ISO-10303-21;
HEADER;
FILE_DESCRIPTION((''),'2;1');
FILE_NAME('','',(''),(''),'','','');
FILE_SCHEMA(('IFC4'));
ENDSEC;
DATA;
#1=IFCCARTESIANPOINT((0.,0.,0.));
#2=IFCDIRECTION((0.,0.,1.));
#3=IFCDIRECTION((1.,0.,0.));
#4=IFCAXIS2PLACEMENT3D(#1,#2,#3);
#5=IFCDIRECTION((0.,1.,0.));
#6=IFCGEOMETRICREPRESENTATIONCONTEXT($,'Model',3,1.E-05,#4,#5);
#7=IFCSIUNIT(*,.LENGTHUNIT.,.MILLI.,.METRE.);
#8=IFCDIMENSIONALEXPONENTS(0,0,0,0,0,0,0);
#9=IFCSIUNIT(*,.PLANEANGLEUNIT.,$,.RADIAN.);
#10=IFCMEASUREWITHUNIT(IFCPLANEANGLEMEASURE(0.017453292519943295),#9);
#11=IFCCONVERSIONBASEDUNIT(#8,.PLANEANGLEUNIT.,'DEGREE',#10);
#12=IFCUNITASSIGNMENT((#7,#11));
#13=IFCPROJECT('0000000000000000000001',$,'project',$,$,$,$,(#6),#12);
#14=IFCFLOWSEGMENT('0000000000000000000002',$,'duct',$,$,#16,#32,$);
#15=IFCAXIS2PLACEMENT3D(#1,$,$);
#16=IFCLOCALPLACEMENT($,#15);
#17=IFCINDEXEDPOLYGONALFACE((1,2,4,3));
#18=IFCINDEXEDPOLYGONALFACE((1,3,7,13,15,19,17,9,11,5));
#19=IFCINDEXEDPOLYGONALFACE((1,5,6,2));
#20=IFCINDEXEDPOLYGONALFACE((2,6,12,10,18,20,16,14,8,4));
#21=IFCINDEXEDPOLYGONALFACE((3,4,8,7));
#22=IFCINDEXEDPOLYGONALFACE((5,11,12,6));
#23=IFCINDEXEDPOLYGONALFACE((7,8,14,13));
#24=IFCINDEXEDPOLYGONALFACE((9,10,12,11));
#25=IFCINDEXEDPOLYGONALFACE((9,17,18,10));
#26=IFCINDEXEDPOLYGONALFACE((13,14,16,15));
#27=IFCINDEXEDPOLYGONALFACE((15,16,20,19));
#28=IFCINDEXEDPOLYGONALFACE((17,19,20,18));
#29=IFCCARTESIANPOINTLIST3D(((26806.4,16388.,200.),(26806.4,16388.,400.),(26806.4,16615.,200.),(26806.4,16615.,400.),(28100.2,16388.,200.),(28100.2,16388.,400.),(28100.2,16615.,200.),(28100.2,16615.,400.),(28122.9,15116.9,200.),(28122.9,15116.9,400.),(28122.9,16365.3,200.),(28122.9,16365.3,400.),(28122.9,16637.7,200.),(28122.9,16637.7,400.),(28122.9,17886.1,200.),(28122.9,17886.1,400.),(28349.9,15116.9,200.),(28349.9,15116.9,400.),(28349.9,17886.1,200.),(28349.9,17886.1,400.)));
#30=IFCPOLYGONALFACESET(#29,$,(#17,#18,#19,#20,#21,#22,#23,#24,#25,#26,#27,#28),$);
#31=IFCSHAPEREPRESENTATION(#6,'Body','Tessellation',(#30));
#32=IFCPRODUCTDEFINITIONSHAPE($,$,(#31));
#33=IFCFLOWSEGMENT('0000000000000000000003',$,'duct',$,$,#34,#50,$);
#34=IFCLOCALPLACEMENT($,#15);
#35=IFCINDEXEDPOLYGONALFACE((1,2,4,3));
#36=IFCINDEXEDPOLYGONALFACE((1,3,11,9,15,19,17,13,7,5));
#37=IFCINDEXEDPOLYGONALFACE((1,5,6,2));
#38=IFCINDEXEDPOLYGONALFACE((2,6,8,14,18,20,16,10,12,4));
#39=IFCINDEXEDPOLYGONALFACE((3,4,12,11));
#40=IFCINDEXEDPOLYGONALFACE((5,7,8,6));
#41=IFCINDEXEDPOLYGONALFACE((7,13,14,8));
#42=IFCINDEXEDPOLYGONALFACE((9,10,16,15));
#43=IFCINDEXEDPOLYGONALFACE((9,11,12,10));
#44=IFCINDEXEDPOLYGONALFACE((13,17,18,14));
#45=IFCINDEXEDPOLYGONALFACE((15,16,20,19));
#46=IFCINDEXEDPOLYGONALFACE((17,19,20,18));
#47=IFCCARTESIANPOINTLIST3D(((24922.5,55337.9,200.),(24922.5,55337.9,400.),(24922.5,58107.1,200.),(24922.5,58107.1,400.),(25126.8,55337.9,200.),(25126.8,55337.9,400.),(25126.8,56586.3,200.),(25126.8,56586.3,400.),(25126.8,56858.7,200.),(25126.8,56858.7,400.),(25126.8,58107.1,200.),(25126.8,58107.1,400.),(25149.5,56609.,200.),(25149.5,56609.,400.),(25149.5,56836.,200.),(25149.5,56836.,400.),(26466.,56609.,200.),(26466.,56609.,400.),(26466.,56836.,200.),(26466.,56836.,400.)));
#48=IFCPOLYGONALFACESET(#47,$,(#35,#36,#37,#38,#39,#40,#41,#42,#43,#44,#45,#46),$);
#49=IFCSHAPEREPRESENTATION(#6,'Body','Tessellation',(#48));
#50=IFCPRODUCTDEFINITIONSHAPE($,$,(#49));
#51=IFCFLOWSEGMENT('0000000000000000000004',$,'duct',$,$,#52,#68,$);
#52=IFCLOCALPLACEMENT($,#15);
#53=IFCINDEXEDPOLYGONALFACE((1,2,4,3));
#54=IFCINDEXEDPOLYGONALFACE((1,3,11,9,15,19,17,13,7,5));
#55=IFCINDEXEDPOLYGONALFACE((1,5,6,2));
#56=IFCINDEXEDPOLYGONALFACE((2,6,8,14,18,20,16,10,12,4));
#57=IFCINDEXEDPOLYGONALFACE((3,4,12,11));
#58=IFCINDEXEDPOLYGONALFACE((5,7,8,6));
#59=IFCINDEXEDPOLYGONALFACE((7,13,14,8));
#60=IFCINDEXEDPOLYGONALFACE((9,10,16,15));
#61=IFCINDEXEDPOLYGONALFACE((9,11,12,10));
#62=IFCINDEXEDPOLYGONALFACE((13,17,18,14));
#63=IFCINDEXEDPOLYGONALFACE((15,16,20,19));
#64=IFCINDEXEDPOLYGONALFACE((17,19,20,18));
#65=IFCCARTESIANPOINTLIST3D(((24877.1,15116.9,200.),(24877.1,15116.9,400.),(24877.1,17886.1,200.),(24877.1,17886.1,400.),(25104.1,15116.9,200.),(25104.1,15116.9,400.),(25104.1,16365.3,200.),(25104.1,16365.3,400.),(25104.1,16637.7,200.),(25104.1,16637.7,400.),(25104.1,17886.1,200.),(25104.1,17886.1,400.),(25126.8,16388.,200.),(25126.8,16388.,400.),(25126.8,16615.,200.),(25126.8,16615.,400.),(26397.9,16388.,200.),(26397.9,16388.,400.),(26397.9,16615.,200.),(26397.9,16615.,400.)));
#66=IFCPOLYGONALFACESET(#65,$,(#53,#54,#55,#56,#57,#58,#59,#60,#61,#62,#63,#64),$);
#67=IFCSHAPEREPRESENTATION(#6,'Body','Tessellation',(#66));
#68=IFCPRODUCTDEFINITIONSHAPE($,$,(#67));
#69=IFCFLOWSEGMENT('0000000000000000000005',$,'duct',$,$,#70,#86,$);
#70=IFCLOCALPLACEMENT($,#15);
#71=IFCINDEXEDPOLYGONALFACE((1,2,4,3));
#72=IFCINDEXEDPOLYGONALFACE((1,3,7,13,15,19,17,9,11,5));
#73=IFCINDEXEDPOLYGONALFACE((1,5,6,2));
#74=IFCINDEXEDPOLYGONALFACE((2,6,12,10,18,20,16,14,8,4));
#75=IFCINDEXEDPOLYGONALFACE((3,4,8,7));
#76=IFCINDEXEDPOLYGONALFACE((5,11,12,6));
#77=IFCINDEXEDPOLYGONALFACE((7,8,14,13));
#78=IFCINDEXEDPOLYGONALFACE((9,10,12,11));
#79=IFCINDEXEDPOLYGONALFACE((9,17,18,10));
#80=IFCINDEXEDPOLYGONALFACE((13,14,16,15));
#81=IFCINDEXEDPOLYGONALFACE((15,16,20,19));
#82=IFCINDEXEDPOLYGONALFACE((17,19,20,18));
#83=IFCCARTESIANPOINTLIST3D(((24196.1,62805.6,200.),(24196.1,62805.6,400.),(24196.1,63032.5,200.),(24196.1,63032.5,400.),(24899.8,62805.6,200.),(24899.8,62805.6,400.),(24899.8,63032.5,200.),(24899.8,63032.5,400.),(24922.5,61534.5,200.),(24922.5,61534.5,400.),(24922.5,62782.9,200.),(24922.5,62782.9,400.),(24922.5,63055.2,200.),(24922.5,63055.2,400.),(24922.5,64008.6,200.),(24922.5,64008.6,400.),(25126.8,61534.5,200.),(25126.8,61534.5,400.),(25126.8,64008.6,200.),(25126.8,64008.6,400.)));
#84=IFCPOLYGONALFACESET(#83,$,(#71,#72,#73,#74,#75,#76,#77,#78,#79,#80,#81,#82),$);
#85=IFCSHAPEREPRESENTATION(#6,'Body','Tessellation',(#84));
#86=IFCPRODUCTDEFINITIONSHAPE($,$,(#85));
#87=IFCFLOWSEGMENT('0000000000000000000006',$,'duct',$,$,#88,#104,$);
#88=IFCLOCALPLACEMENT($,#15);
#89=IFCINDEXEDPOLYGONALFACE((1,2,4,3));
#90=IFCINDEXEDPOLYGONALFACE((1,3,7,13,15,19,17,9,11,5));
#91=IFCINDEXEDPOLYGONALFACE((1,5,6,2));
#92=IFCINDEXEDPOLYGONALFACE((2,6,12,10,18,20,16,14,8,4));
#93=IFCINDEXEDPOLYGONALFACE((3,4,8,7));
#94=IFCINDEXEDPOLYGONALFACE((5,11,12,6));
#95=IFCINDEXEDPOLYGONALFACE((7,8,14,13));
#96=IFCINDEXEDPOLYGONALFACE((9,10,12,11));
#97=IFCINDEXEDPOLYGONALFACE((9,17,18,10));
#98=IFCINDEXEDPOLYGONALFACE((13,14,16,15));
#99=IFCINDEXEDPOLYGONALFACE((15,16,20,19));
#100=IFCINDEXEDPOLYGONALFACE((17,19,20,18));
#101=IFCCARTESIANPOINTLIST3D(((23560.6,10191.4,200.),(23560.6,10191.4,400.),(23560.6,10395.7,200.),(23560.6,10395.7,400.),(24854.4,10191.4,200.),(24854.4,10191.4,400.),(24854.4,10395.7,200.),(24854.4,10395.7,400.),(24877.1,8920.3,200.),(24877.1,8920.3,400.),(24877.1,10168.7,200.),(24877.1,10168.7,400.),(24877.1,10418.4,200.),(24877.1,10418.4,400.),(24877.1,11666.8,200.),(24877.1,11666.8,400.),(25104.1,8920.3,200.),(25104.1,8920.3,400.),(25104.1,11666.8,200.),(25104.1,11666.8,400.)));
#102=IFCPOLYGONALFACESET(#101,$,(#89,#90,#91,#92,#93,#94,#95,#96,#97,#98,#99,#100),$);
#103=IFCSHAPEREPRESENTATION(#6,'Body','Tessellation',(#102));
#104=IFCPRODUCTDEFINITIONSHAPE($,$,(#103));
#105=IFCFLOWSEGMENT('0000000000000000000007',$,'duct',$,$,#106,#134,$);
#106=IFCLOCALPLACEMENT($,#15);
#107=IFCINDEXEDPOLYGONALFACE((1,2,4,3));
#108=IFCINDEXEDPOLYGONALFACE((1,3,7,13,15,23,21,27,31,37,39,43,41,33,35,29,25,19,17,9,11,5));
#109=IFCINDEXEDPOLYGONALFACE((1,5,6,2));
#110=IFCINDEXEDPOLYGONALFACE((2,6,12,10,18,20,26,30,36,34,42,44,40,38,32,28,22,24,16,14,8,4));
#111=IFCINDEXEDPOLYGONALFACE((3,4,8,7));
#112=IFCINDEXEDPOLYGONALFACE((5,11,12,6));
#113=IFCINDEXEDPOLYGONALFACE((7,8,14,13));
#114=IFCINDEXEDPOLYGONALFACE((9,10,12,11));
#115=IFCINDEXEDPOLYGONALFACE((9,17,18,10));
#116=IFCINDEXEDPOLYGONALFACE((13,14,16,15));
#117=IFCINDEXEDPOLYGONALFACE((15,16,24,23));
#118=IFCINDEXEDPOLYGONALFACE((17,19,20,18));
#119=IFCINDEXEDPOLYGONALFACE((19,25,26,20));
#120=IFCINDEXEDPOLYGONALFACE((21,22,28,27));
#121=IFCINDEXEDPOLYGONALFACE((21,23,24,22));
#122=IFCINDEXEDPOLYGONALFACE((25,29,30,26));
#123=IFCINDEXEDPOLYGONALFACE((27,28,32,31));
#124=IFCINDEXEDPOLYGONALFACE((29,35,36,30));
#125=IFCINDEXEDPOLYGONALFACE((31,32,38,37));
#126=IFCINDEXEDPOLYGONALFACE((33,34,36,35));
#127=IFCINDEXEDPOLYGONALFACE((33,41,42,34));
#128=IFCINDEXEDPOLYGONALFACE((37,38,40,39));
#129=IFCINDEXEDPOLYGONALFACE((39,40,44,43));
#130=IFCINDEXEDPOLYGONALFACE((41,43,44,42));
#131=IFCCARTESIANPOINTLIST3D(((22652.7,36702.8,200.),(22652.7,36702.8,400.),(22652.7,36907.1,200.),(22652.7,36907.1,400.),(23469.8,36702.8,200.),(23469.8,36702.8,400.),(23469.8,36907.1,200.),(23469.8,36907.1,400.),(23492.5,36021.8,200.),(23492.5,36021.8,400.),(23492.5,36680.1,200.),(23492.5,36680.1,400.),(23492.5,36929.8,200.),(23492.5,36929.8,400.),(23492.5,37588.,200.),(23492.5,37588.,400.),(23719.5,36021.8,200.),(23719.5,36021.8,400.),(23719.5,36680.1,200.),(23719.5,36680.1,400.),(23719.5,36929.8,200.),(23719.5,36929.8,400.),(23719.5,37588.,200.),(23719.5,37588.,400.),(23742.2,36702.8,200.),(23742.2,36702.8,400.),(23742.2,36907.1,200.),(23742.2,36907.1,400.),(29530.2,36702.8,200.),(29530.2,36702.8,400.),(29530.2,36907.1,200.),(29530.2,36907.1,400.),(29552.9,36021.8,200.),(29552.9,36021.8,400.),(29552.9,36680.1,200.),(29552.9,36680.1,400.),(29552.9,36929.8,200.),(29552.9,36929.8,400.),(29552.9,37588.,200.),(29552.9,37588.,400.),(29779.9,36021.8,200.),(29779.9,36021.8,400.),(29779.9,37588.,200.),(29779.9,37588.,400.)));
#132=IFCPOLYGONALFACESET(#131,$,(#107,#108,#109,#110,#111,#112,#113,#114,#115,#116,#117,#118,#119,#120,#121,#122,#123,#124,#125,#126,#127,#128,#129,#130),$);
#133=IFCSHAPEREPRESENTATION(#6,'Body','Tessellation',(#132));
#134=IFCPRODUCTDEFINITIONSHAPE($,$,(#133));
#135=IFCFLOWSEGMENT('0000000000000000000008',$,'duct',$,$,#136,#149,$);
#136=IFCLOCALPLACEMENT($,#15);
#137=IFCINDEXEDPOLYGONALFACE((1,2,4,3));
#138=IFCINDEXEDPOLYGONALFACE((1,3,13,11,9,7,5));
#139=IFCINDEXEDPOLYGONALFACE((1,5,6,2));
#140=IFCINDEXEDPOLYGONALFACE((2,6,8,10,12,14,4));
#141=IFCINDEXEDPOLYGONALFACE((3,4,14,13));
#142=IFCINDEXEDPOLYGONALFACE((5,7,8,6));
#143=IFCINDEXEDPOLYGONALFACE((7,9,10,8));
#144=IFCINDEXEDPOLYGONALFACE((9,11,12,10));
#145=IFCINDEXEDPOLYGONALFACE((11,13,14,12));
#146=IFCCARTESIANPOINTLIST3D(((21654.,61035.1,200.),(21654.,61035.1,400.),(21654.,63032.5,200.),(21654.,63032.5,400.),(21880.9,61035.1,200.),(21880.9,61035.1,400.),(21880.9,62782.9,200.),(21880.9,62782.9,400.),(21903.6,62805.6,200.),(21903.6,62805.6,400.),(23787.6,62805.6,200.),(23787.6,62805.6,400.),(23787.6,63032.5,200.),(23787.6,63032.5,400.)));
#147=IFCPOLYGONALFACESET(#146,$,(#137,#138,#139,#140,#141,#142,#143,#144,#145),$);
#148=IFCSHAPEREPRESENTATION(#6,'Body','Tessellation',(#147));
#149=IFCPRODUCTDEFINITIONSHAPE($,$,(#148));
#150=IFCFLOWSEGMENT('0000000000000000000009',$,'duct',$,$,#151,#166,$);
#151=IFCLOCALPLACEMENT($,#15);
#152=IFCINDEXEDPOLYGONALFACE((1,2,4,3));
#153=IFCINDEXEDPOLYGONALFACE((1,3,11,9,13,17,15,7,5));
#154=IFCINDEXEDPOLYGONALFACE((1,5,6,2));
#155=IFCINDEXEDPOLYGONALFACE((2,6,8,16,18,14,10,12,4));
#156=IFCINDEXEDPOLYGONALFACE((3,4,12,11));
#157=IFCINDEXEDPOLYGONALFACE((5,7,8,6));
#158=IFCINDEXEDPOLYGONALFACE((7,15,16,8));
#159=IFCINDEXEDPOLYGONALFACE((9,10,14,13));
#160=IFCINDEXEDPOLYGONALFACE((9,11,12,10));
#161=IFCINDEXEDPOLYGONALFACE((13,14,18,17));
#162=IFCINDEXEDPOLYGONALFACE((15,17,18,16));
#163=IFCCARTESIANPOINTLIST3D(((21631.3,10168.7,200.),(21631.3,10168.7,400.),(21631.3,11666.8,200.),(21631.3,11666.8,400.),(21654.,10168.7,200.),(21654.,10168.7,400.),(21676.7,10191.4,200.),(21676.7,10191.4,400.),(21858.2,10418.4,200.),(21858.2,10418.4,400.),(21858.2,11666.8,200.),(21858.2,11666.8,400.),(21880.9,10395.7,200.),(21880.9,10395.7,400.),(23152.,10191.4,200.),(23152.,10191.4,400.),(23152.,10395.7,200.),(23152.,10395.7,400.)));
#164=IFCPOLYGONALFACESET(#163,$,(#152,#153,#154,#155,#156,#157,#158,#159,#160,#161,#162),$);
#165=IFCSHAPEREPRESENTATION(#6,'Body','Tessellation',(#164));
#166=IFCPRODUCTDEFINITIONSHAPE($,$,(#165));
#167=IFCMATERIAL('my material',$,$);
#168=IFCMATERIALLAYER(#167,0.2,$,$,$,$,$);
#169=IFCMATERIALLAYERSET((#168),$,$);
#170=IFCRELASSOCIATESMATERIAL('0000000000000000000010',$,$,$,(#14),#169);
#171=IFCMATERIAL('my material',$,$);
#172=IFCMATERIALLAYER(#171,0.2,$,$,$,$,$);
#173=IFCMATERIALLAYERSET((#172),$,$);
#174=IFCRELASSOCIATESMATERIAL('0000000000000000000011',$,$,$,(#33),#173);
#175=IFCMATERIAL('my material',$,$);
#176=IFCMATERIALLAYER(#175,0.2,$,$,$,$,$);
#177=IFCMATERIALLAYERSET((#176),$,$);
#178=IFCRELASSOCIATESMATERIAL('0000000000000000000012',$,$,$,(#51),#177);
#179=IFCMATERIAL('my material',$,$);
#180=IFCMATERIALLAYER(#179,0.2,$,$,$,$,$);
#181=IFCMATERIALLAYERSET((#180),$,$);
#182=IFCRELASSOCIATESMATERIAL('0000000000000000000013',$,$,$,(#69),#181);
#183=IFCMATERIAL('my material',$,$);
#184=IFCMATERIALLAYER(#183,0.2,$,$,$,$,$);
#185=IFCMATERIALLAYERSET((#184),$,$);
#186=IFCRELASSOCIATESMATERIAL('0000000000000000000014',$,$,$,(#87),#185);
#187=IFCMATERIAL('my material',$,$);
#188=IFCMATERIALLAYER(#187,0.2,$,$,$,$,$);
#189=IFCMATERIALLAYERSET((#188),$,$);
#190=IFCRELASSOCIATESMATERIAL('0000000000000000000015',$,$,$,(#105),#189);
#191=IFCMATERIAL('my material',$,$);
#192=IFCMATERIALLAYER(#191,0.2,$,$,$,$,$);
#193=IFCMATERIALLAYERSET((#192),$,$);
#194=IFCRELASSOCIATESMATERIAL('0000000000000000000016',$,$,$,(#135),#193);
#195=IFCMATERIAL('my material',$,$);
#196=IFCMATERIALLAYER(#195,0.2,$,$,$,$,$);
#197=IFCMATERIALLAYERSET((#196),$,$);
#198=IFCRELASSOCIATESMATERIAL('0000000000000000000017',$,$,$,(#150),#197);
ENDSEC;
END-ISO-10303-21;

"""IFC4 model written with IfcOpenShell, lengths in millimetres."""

from ifc_helpers import new_model, entity, si_unit, converted_unit, direction, frame, origin_with_axes, place, context, project, polyline, outline, extrude, material, layer, layer_set, layer_usage, element, save


model = new_model("IFC4")

# Units and contexts
model_context = context("Model", 3, precision=1e-05, world=origin_with_axes(), true_north=direction((0.0, 1.0, 0.0)))
ifc_project = project(units=[si_unit("LENGTHUNIT", "METRE", prefix="MILLI"), converted_unit("PLANEANGLEUNIT", "DEGREE", entity("IfcPlaneAngleMeasure", 0.017453292519943295), si_unit("PLANEANGLEUNIT", "RADIAN"), dimensions=[0, 0, 0, 0, 0, 0, 0])], contexts=[model_context])

# Flow segments
ifc_material_1 = material(Name="my material")
ifc_layer_1 = layer(ifc_material_1, 0.2)
ifc_layer_set_1 = layer_set([ifc_layer_1])
ifc_layer_usage_1 = layer_usage(ifc_layer_set_1, "AXIS2", "POSITIVE", -0.1)
flow_segment_1_placement = place(None, origin_with_axes())
element("IfcFlowSegment", 1, at=flow_segment_1_placement, material=ifc_layer_usage_1, Name="duct", context=model_context, shape_type="SweptSolid", body=[
    extrude(outline(polyline([(26806.4, 16388.0), (28100.2, 16388.0), (28122.9, 16365.3), (28122.9, 15116.9), (28349.9, 15116.9), (28349.9, 17886.1), (28122.9, 17886.1), (28122.9, 16637.7), (28100.2, 16615.0), (26806.4, 16615.0), (26806.4, 16388.0)])), frame((0.0, 0.0, 200.0), z_axis=(0.0, 0.0, 1.0), x_axis=(1.0, 0.0, 0.0)), (0.0, 0.0, 1.0), 200.0),
])
ifc_material_2 = material(Name="my material")
ifc_layer_2 = layer(ifc_material_2, 0.2)
ifc_layer_set_2 = layer_set([ifc_layer_2])
ifc_layer_usage_2 = layer_usage(ifc_layer_set_2, "AXIS2", "POSITIVE", -0.1)
flow_segment_2_placement = place(None, origin_with_axes())
element("IfcFlowSegment", 2, at=flow_segment_2_placement, material=ifc_layer_usage_2, Name="duct", context=model_context, shape_type="SweptSolid", body=[
    extrude(outline(polyline([(24922.5, 55337.9), (25126.8, 55337.9), (25126.8, 56586.3), (25149.5, 56609.0), (26466.0, 56609.0), (26466.0, 56836.0), (25149.5, 56836.0), (25126.8, 56858.7), (25126.8, 58107.1), (24922.5, 58107.1), (24922.5, 55337.9)])), frame((0.0, 0.0, 200.0), z_axis=(0.0, 0.0, 1.0), x_axis=(1.0, 0.0, 0.0)), (0.0, 0.0, 1.0), 200.0),
])
ifc_material_3 = material(Name="my material")
ifc_layer_3 = layer(ifc_material_3, 0.2)
ifc_layer_set_3 = layer_set([ifc_layer_3])
ifc_layer_usage_3 = layer_usage(ifc_layer_set_3, "AXIS2", "POSITIVE", -0.1)
flow_segment_3_placement = place(None, origin_with_axes())
element("IfcFlowSegment", 3, at=flow_segment_3_placement, material=ifc_layer_usage_3, Name="duct", context=model_context, shape_type="SweptSolid", body=[
    extrude(outline(polyline([(24877.1, 15116.9), (25104.1, 15116.9), (25104.1, 16365.3), (25126.8, 16388.0), (26397.9, 16388.0), (26397.9, 16615.0), (25126.8, 16615.0), (25104.1, 16637.7), (25104.1, 17886.1), (24877.1, 17886.1), (24877.1, 15116.9)])), frame((0.0, 0.0, 200.0), z_axis=(0.0, 0.0, 1.0), x_axis=(1.0, 0.0, 0.0)), (0.0, 0.0, 1.0), 200.0),
])
ifc_material_4 = material(Name="my material")
ifc_layer_4 = layer(ifc_material_4, 0.2)
ifc_layer_set_4 = layer_set([ifc_layer_4])
ifc_layer_usage_4 = layer_usage(ifc_layer_set_4, "AXIS2", "POSITIVE", -0.1)
flow_segment_4_placement = place(None, origin_with_axes())
element("IfcFlowSegment", 4, at=flow_segment_4_placement, material=ifc_layer_usage_4, Name="duct", context=model_context, shape_type="SweptSolid", body=[
    extrude(outline(polyline([(24196.1, 62805.6), (24899.8, 62805.6), (24922.5, 62782.9), (24922.5, 61534.5), (25126.8, 61534.5), (25126.8, 64008.6), (24922.5, 64008.6), (24922.5, 63055.2), (24899.8, 63032.5), (24196.1, 63032.5), (24196.1, 62805.6)])), frame((0.0, 0.0, 200.0), z_axis=(0.0, 0.0, 1.0), x_axis=(1.0, 0.0, 0.0)), (0.0, 0.0, 1.0), 200.0),
])
ifc_material_5 = material(Name="my material")
ifc_layer_5 = layer(ifc_material_5, 0.2)
ifc_layer_set_5 = layer_set([ifc_layer_5])
ifc_layer_usage_5 = layer_usage(ifc_layer_set_5, "AXIS2", "POSITIVE", -0.1)
flow_segment_5_placement = place(None, origin_with_axes())
element("IfcFlowSegment", 5, at=flow_segment_5_placement, material=ifc_layer_usage_5, Name="duct", context=model_context, shape_type="SweptSolid", body=[
    extrude(outline(polyline([(23560.6, 10191.4), (24854.4, 10191.4), (24877.1, 10168.7), (24877.1, 8920.3), (25104.1, 8920.3), (25104.1, 11666.8), (24877.1, 11666.8), (24877.1, 10418.4), (24854.4, 10395.7), (23560.6, 10395.7), (23560.6, 10191.4)])), frame((0.0, 0.0, 200.0), z_axis=(0.0, 0.0, 1.0), x_axis=(1.0, 0.0, 0.0)), (0.0, 0.0, 1.0), 200.0),
])
ifc_material_6 = material(Name="my material")
ifc_layer_6 = layer(ifc_material_6, 0.2)
ifc_layer_set_6 = layer_set([ifc_layer_6])
ifc_layer_usage_6 = layer_usage(ifc_layer_set_6, "AXIS2", "POSITIVE", -0.1)
flow_segment_6_placement = place(None, origin_with_axes())
element("IfcFlowSegment", 6, at=flow_segment_6_placement, material=ifc_layer_usage_6, Name="duct", context=model_context, shape_type="SweptSolid", body=[
    extrude(outline(polyline([(22652.7, 36702.8), (23469.8, 36702.8), (23492.5, 36680.1), (23492.5, 36021.8), (23719.5, 36021.8), (23719.5, 36680.1), (23742.2, 36702.8), (29530.2, 36702.8), (29552.9, 36680.1), (29552.9, 36021.8), (29779.9, 36021.8), (29779.9, 37588.0), (29552.9, 37588.0), (29552.9, 36929.8), (29530.2, 36907.1), (23742.2, 36907.1), (23719.5, 36929.8), (23719.5, 37588.0), (23492.5, 37588.0), (23492.5, 36929.8), (23469.8, 36907.1), (22652.7, 36907.1), (22652.7, 36702.8)])), frame((0.0, 0.0, 200.0), z_axis=(0.0, 0.0, 1.0), x_axis=(1.0, 0.0, 0.0)), (0.0, 0.0, 1.0), 200.0),
])
ifc_material_7 = material(Name="my material")
ifc_layer_7 = layer(ifc_material_7, 0.2)
ifc_layer_set_7 = layer_set([ifc_layer_7])
ifc_layer_usage_7 = layer_usage(ifc_layer_set_7, "AXIS2", "POSITIVE", -0.1)
flow_segment_7_placement = place(None, origin_with_axes())
element("IfcFlowSegment", 7, at=flow_segment_7_placement, material=ifc_layer_usage_7, Name="duct", context=model_context, shape_type="SweptSolid", body=[
    extrude(outline(polyline([(21654.0, 61035.1), (21880.9, 61035.1), (21880.9, 62782.9), (21903.6, 62805.6), (23787.6, 62805.6), (23787.6, 63032.5), (21654.0, 63032.5), (21654.0, 61035.1)])), frame((0.0, 0.0, 200.0), z_axis=(0.0, 0.0, 1.0), x_axis=(1.0, 0.0, 0.0)), (0.0, 0.0, 1.0), 200.0),
])
ifc_material_8 = material(Name="my material")
ifc_layer_8 = layer(ifc_material_8, 0.2)
ifc_layer_set_8 = layer_set([ifc_layer_8])
ifc_layer_usage_8 = layer_usage(ifc_layer_set_8, "AXIS2", "POSITIVE", -0.1)
flow_segment_8_placement = place(None, origin_with_axes())
element("IfcFlowSegment", 8, at=flow_segment_8_placement, material=ifc_layer_usage_8, Name="duct", context=model_context, shape_type="SweptSolid", body=[
    extrude(outline(polyline([(21631.3, 10168.7), (21654.0, 10168.7), (21676.7, 10191.4), (23152.0, 10191.4), (23152.0, 10395.7), (21880.9, 10395.7), (21858.2, 10418.4), (21858.2, 11666.8), (21631.3, 11666.8), (21631.3, 10168.7)])), frame((0.0, 0.0, 200.0), z_axis=(0.0, 0.0, 1.0), x_axis=(1.0, 0.0, 0.0)), (0.0, 0.0, 1.0), 200.0),
])

save(model, "model.ifc")
